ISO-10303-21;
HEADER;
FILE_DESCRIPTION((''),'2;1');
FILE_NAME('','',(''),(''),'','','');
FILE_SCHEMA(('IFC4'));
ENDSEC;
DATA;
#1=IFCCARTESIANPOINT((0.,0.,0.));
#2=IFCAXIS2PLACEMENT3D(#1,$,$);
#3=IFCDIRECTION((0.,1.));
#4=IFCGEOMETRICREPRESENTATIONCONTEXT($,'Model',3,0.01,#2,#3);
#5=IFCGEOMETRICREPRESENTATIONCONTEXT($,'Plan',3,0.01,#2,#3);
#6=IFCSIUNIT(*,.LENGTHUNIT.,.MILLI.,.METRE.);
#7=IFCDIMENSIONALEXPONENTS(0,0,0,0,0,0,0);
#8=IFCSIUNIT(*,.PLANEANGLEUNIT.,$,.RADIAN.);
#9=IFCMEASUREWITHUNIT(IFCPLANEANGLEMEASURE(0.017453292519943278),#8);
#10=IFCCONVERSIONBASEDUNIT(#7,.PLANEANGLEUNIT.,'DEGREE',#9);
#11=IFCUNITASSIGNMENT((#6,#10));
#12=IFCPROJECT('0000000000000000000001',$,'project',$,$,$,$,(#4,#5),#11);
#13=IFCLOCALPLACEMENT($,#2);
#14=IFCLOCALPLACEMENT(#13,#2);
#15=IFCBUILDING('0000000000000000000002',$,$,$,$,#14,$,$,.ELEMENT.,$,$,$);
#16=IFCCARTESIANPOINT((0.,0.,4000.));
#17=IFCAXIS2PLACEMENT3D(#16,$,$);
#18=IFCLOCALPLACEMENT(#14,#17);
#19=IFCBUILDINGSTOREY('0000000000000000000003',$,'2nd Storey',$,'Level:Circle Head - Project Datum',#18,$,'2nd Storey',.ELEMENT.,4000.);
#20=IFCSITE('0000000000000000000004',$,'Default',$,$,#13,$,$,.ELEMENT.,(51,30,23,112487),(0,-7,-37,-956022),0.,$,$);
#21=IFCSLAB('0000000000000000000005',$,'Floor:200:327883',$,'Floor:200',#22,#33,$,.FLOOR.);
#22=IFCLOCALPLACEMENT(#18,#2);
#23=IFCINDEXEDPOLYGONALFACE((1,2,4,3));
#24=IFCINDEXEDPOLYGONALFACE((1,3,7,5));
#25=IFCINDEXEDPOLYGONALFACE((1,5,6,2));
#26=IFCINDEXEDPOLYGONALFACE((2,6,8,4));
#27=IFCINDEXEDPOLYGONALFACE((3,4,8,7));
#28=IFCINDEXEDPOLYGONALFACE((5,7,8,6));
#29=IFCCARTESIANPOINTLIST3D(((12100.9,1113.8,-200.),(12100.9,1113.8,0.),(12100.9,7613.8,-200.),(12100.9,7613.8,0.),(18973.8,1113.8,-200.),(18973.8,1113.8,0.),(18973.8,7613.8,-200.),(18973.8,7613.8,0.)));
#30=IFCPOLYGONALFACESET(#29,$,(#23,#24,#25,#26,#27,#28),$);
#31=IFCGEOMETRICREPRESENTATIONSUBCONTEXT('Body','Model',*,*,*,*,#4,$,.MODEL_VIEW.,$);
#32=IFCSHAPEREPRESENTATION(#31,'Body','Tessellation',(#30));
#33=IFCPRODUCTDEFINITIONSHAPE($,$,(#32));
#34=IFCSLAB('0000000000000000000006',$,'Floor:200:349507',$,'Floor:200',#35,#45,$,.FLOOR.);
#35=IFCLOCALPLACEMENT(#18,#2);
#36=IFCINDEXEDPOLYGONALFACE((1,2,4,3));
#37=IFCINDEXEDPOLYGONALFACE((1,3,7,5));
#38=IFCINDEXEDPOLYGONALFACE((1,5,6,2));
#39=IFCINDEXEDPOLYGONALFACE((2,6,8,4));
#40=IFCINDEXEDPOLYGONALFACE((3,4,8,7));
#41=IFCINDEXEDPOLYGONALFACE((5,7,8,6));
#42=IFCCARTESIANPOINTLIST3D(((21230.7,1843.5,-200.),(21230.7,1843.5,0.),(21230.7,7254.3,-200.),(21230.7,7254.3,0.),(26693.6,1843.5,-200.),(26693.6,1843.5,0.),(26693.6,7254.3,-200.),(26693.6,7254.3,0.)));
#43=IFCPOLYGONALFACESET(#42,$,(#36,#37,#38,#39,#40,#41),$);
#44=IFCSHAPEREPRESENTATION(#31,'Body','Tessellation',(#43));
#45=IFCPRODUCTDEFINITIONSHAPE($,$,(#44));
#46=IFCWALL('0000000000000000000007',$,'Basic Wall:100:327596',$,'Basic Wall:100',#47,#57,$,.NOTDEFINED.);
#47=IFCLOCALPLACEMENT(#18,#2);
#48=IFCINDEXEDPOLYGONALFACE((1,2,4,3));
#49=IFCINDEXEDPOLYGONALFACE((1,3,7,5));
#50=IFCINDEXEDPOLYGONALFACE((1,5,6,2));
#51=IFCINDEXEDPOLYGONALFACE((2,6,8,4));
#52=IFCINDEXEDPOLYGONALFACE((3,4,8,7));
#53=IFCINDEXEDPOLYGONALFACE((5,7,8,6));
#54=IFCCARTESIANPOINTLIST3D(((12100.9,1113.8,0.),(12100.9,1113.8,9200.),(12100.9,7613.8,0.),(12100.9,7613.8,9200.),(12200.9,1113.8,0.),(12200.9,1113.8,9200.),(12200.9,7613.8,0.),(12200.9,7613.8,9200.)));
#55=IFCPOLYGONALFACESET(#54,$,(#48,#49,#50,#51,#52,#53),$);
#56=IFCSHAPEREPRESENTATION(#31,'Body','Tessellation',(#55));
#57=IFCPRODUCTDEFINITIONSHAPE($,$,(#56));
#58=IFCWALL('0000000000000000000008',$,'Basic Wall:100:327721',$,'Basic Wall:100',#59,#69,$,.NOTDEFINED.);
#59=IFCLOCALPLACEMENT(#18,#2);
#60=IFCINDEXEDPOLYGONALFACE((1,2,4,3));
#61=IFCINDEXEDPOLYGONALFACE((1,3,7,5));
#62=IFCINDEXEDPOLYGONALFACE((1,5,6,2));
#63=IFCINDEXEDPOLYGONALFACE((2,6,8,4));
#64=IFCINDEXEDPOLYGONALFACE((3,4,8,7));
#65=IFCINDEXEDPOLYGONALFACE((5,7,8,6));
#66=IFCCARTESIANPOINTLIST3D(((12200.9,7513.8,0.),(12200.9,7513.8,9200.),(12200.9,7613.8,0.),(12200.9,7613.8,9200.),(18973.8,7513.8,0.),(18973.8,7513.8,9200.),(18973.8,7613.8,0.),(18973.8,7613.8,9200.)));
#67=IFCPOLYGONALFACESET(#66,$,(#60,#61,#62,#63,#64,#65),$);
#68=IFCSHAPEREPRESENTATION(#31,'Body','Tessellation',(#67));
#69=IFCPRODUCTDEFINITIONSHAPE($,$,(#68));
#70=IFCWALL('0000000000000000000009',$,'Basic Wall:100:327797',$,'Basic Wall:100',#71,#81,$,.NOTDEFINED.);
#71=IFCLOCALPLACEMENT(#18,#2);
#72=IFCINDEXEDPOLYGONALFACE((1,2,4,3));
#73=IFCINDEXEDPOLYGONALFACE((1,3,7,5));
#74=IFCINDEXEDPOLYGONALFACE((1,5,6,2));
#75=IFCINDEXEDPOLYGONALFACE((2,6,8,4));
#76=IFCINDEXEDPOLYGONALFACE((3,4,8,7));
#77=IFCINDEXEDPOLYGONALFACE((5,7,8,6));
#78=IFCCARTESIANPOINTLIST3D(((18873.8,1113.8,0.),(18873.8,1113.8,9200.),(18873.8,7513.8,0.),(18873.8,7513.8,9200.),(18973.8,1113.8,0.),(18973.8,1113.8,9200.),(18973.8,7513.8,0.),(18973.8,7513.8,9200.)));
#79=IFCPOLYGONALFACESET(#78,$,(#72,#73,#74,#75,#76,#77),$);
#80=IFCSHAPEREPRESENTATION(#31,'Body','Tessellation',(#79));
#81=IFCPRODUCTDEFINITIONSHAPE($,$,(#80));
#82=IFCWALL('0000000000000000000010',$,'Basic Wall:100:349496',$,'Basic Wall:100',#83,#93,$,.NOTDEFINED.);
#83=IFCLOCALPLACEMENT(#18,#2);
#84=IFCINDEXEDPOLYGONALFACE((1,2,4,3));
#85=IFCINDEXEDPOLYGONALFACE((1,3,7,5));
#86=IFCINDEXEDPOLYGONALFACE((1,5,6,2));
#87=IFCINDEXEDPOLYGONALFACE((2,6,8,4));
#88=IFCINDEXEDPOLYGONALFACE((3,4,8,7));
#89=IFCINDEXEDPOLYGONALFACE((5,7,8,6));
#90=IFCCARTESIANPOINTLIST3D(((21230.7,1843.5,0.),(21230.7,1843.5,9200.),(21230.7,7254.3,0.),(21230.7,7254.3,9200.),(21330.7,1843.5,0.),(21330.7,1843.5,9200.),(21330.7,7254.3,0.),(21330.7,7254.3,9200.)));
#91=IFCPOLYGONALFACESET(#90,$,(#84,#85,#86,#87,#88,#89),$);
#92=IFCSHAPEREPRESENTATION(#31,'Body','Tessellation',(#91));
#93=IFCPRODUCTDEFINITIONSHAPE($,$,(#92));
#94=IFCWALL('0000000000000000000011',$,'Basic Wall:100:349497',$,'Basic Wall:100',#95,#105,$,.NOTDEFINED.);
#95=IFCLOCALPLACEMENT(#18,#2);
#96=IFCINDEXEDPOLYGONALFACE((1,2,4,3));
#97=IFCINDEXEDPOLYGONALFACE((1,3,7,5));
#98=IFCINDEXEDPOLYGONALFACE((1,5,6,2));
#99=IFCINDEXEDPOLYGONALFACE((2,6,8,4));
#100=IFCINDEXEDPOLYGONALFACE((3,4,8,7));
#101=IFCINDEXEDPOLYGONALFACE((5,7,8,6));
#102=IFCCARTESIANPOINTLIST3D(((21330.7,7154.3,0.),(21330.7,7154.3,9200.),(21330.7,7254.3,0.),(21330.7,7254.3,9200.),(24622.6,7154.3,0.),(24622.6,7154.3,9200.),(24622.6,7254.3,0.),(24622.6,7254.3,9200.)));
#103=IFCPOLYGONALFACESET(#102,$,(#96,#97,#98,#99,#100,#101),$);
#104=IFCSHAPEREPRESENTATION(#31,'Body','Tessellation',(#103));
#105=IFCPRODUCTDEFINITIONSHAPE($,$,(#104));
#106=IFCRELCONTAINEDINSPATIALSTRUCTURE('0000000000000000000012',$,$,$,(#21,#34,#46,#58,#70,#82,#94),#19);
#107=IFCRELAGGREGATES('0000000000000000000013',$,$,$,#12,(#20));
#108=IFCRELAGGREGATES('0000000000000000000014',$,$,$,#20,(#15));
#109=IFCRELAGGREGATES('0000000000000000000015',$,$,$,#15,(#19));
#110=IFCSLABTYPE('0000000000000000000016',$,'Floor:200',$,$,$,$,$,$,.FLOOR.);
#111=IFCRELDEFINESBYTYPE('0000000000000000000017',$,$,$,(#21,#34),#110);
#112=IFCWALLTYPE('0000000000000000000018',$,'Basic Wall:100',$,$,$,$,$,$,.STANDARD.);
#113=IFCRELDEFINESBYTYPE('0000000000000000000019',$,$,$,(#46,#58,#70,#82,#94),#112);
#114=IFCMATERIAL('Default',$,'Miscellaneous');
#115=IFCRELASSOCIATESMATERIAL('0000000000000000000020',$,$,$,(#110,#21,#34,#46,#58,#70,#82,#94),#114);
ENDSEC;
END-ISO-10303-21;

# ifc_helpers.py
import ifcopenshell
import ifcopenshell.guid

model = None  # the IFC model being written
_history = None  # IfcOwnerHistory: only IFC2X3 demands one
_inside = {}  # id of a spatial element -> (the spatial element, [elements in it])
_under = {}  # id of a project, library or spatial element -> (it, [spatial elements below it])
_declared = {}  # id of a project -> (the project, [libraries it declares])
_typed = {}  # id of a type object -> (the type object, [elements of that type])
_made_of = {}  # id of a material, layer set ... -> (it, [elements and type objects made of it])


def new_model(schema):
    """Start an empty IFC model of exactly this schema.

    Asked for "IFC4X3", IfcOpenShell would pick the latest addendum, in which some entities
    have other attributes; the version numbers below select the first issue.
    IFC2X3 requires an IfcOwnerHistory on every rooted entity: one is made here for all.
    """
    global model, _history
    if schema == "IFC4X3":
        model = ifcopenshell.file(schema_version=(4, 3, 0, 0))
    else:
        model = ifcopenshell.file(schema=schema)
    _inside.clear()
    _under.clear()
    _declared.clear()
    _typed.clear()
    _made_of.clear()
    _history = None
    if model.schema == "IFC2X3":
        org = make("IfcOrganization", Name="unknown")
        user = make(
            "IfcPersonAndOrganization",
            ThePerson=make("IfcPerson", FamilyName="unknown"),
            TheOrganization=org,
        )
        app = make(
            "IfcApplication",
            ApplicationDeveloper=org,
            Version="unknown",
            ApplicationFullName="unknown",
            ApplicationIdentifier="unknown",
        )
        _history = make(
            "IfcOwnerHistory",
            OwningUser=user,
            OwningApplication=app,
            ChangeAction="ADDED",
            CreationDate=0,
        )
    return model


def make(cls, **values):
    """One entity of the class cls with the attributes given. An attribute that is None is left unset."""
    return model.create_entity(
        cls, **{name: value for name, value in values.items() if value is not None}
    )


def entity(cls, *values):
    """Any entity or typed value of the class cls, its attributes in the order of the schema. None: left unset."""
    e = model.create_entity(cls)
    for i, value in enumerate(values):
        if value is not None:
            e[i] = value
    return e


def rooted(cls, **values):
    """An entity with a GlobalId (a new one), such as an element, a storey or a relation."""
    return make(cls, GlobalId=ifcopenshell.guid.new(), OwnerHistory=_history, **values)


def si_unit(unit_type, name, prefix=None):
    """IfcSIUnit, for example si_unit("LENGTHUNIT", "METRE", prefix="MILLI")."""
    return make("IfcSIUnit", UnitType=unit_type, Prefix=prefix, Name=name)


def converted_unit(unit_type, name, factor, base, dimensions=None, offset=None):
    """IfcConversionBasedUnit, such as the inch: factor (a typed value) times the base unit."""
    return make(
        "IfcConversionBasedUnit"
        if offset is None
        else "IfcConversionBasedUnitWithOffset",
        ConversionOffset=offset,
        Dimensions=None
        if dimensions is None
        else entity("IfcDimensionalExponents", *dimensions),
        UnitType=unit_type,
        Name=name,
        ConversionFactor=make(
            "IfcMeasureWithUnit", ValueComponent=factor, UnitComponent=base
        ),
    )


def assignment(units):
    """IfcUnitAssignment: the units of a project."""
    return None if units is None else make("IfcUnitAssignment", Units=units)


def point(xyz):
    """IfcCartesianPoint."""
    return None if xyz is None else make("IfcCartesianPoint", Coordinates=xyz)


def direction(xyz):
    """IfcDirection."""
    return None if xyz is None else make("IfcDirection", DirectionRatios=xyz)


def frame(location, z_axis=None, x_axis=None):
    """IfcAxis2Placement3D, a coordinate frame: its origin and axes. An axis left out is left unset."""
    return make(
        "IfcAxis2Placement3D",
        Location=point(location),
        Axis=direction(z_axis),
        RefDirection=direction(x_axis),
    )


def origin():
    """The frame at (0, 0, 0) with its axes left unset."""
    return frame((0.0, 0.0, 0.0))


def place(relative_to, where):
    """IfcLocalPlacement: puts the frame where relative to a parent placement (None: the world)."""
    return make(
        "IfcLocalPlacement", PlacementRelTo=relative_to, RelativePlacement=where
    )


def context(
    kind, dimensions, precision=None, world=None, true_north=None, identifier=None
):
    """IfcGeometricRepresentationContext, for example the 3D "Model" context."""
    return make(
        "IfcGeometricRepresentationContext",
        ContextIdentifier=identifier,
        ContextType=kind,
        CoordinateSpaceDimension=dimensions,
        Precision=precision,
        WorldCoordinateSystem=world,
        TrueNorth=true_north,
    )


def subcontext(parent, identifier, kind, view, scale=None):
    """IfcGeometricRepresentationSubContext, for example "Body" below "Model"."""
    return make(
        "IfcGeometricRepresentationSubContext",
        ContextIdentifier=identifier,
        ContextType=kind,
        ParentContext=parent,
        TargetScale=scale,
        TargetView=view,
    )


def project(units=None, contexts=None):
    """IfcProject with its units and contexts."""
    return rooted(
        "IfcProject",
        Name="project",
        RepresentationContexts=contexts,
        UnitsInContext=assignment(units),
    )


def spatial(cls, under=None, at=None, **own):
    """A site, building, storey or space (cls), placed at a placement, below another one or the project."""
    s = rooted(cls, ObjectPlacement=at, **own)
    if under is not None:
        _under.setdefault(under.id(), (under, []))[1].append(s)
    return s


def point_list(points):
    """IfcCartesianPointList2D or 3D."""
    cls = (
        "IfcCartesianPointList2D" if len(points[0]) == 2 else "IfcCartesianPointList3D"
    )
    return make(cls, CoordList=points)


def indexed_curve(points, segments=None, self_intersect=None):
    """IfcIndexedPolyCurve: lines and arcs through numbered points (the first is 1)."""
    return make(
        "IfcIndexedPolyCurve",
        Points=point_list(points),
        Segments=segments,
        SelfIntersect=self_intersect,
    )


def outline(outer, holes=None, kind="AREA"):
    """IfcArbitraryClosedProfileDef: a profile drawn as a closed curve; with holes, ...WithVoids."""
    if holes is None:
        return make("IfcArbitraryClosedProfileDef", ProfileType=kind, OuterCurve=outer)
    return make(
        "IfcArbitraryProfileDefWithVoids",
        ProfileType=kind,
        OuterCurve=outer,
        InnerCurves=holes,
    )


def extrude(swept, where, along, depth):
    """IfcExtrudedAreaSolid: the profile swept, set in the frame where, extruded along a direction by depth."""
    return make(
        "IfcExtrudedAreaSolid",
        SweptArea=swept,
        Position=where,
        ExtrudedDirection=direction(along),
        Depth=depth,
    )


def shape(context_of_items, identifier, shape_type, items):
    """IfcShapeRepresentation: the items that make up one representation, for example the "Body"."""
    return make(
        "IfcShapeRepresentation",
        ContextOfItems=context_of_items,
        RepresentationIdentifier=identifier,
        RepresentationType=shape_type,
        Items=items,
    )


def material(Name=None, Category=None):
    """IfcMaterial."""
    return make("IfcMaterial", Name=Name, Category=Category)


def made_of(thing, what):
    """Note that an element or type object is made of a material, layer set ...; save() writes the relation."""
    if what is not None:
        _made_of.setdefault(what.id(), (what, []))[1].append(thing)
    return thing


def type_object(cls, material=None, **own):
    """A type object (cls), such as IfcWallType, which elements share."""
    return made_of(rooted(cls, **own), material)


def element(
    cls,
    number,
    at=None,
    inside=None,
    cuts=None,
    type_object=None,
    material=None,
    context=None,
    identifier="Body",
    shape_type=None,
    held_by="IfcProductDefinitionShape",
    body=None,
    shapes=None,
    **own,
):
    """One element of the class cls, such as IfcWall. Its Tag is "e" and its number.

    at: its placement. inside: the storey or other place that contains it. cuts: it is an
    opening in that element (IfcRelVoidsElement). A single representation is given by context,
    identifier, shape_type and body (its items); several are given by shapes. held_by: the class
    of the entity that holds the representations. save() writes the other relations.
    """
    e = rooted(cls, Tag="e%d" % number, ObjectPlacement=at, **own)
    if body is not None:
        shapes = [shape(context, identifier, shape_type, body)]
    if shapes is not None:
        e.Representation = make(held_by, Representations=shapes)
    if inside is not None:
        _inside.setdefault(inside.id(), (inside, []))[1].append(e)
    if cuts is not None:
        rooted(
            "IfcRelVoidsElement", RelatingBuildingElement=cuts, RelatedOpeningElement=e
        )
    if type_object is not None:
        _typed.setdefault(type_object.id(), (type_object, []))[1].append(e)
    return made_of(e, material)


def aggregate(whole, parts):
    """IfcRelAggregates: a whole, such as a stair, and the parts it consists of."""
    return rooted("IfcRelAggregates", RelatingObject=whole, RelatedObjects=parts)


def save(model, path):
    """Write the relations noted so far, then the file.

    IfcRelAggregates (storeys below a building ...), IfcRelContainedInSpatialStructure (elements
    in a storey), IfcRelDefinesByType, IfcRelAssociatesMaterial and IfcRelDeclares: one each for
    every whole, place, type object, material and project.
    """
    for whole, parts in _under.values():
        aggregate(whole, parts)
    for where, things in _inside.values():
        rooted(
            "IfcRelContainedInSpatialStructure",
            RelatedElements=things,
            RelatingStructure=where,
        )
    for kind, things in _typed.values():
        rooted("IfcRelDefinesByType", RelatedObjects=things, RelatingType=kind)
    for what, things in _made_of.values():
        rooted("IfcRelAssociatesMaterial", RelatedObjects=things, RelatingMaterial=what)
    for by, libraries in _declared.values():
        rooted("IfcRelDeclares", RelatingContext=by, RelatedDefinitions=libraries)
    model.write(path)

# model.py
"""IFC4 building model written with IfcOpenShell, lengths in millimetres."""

from ifc_helpers import new_model, entity, si_unit, converted_unit, direction, frame, origin, place, context, subcontext, project, spatial, indexed_curve, outline, extrude, material, type_object, element, save


model = new_model("IFC4")

# Units and contexts
model_context = context("Model", 3, precision=0.01, world=origin(), true_north=direction((0.0, 1.0)))
plan_context = context("Plan", 3, precision=0.01, world=origin(), true_north=direction((0.0, 1.0)))
body_context = subcontext(model_context, "Body", "Model", "MODEL_VIEW")
ifc_project = project(units=[si_unit("LENGTHUNIT", "METRE", prefix="MILLI"), converted_unit("PLANEANGLEUNIT", "DEGREE", entity("IfcPlaneAngleMeasure", 0.017453292519943278), si_unit("PLANEANGLEUNIT", "RADIAN"), dimensions=[0, 0, 0, 0, 0, 0, 0])], contexts=[model_context, plan_context])

# Site, building, storey
site_placement = place(None, origin())
site = spatial("IfcSite", under=ifc_project, at=site_placement, Name="Default", CompositionType="ELEMENT", RefLatitude=(51, 30, 23, 112487), RefLongitude=(0, -7, -37, -956022), RefElevation=0.0)
building_placement = place(site_placement, origin())
building = spatial("IfcBuilding", under=site, at=building_placement, CompositionType="ELEMENT")
storey_placement = place(building_placement, frame((0.0, 0.0, 4000.0)))
storey = spatial("IfcBuildingStorey", under=building, at=storey_placement, Name="2nd Storey", ObjectType="Level:Circle Head - Project Datum", LongName="2nd Storey", CompositionType="ELEMENT", Elevation=4000.0)

# Slabs
ifc_material = material(Name="Default", Category="Miscellaneous")
slab_type = type_object("IfcSlabType", Name="Floor:200", PredefinedType="FLOOR", material=ifc_material)
slab_1_placement = place(storey_placement, origin())
element("IfcSlab", 1, at=slab_1_placement, inside=storey, type_object=slab_type, material=ifc_material, Name="Floor:200:327883", ObjectType="Floor:200", PredefinedType="FLOOR", context=body_context, shape_type="SweptSolid", body=[
    extrude(outline(indexed_curve([(-3250.0, -3436.4), (3250.0, -3436.4), (3250.0, 3436.4), (-3250.0, 3436.4), (-3250.0, -3436.4)], self_intersect=False)), frame((15537.4, 4363.8, 0.0), z_axis=(0.0, 0.0, -1.0), x_axis=(0.0, 1.0, 0.0)), (0.0, 0.0, 1.0), 200.0),
])
slab_2_placement = place(storey_placement, origin())
element("IfcSlab", 2, at=slab_2_placement, inside=storey, type_object=slab_type, material=ifc_material, Name="Floor:200:349507", ObjectType="Floor:200", PredefinedType="FLOOR", context=body_context, shape_type="SweptSolid", body=[
    extrude(outline(indexed_curve([(-2705.4, -2731.4), (2705.4, -2731.4), (2705.4, 2731.4), (-2705.4, 2731.4), (-2705.4, -2731.4)], self_intersect=False)), frame((23962.1, 4548.9, 0.0), z_axis=(0.0, 0.0, -1.0), x_axis=(0.0, 1.0, 0.0)), (0.0, 0.0, 1.0), 200.0),
])

# Walls
wall_type = type_object("IfcWallType", Name="Basic Wall:100", PredefinedType="STANDARD")
wall_1_placement = place(storey_placement, frame((12150.9, 1113.8, 0.0), z_axis=(0.0, 0.0, 1.0), x_axis=(0.0, 1.0, 0.0)))
element("IfcWall", 3, at=wall_1_placement, inside=storey, type_object=wall_type, material=ifc_material, Name="Basic Wall:100:327596", ObjectType="Basic Wall:100", PredefinedType="NOTDEFINED", context=body_context, shape_type="SweptSolid", body=[
    extrude(outline(indexed_curve([(6500.0, 50.0), (0.0, 50.0), (0.0, -50.0), (6500.0, -50.0), (6500.0, 50.0)], self_intersect=False)), origin(), (0.0, 0.0, 1.0), 9200.0),
])
wall_2_placement = place(storey_placement, frame((12200.9, 7563.8, 0.0)))
element("IfcWall", 4, at=wall_2_placement, inside=storey, type_object=wall_type, material=ifc_material, Name="Basic Wall:100:327721", ObjectType="Basic Wall:100", PredefinedType="NOTDEFINED", context=body_context, shape_type="SweptSolid", body=[
    extrude(outline(indexed_curve([(6772.9, 50.0), (0.0, 50.0), (0.0, -50.0), (6772.9, -50.0), (6772.9, 50.0)], self_intersect=False)), origin(), (0.0, 0.0, 1.0), 9200.0),
])
wall_3_placement = place(storey_placement, frame((18923.8, 7513.8, 0.0), z_axis=(0.0, 0.0, 1.0), x_axis=(0.0, -1.0, 0.0)))
element("IfcWall", 5, at=wall_3_placement, inside=storey, type_object=wall_type, material=ifc_material, Name="Basic Wall:100:327797", ObjectType="Basic Wall:100", PredefinedType="NOTDEFINED", context=body_context, shape_type="SweptSolid", body=[
    extrude(outline(indexed_curve([(6400.0, 50.0), (0.0, 50.0), (0.0, -50.0), (6400.0, -50.0), (6400.0, 50.0)], self_intersect=False)), origin(), (0.0, 0.0, 1.0), 9200.0),
])
wall_4_placement = place(storey_placement, frame((21280.7, 1843.5, 0.0), z_axis=(0.0, 0.0, 1.0), x_axis=(0.0, 1.0, 0.0)))
element("IfcWall", 6, at=wall_4_placement, inside=storey, type_object=wall_type, material=ifc_material, Name="Basic Wall:100:349496", ObjectType="Basic Wall:100", PredefinedType="NOTDEFINED", context=body_context, shape_type="SweptSolid", body=[
    extrude(outline(indexed_curve([(5410.9, 50.0), (0.0, 50.0), (0.0, -50.0), (5410.9, -50.0), (5410.9, 50.0)], self_intersect=False)), origin(), (0.0, 0.0, 1.0), 9200.0),
])
wall_5_placement = place(storey_placement, frame((21330.7, 7204.3, 0.0)))
element("IfcWall", 7, at=wall_5_placement, inside=storey, type_object=wall_type, material=ifc_material, Name="Basic Wall:100:349497", ObjectType="Basic Wall:100", PredefinedType="NOTDEFINED", context=body_context, shape_type="SweptSolid", body=[
    extrude(outline(indexed_curve([(3291.8, 50.0), (0.0, 50.0), (0.0, -50.0), (3291.8, -50.0), (3291.8, 50.0)], self_intersect=False)), origin(), (0.0, 0.0, 1.0), 9200.0),
])

save(model, "model.ifc")
